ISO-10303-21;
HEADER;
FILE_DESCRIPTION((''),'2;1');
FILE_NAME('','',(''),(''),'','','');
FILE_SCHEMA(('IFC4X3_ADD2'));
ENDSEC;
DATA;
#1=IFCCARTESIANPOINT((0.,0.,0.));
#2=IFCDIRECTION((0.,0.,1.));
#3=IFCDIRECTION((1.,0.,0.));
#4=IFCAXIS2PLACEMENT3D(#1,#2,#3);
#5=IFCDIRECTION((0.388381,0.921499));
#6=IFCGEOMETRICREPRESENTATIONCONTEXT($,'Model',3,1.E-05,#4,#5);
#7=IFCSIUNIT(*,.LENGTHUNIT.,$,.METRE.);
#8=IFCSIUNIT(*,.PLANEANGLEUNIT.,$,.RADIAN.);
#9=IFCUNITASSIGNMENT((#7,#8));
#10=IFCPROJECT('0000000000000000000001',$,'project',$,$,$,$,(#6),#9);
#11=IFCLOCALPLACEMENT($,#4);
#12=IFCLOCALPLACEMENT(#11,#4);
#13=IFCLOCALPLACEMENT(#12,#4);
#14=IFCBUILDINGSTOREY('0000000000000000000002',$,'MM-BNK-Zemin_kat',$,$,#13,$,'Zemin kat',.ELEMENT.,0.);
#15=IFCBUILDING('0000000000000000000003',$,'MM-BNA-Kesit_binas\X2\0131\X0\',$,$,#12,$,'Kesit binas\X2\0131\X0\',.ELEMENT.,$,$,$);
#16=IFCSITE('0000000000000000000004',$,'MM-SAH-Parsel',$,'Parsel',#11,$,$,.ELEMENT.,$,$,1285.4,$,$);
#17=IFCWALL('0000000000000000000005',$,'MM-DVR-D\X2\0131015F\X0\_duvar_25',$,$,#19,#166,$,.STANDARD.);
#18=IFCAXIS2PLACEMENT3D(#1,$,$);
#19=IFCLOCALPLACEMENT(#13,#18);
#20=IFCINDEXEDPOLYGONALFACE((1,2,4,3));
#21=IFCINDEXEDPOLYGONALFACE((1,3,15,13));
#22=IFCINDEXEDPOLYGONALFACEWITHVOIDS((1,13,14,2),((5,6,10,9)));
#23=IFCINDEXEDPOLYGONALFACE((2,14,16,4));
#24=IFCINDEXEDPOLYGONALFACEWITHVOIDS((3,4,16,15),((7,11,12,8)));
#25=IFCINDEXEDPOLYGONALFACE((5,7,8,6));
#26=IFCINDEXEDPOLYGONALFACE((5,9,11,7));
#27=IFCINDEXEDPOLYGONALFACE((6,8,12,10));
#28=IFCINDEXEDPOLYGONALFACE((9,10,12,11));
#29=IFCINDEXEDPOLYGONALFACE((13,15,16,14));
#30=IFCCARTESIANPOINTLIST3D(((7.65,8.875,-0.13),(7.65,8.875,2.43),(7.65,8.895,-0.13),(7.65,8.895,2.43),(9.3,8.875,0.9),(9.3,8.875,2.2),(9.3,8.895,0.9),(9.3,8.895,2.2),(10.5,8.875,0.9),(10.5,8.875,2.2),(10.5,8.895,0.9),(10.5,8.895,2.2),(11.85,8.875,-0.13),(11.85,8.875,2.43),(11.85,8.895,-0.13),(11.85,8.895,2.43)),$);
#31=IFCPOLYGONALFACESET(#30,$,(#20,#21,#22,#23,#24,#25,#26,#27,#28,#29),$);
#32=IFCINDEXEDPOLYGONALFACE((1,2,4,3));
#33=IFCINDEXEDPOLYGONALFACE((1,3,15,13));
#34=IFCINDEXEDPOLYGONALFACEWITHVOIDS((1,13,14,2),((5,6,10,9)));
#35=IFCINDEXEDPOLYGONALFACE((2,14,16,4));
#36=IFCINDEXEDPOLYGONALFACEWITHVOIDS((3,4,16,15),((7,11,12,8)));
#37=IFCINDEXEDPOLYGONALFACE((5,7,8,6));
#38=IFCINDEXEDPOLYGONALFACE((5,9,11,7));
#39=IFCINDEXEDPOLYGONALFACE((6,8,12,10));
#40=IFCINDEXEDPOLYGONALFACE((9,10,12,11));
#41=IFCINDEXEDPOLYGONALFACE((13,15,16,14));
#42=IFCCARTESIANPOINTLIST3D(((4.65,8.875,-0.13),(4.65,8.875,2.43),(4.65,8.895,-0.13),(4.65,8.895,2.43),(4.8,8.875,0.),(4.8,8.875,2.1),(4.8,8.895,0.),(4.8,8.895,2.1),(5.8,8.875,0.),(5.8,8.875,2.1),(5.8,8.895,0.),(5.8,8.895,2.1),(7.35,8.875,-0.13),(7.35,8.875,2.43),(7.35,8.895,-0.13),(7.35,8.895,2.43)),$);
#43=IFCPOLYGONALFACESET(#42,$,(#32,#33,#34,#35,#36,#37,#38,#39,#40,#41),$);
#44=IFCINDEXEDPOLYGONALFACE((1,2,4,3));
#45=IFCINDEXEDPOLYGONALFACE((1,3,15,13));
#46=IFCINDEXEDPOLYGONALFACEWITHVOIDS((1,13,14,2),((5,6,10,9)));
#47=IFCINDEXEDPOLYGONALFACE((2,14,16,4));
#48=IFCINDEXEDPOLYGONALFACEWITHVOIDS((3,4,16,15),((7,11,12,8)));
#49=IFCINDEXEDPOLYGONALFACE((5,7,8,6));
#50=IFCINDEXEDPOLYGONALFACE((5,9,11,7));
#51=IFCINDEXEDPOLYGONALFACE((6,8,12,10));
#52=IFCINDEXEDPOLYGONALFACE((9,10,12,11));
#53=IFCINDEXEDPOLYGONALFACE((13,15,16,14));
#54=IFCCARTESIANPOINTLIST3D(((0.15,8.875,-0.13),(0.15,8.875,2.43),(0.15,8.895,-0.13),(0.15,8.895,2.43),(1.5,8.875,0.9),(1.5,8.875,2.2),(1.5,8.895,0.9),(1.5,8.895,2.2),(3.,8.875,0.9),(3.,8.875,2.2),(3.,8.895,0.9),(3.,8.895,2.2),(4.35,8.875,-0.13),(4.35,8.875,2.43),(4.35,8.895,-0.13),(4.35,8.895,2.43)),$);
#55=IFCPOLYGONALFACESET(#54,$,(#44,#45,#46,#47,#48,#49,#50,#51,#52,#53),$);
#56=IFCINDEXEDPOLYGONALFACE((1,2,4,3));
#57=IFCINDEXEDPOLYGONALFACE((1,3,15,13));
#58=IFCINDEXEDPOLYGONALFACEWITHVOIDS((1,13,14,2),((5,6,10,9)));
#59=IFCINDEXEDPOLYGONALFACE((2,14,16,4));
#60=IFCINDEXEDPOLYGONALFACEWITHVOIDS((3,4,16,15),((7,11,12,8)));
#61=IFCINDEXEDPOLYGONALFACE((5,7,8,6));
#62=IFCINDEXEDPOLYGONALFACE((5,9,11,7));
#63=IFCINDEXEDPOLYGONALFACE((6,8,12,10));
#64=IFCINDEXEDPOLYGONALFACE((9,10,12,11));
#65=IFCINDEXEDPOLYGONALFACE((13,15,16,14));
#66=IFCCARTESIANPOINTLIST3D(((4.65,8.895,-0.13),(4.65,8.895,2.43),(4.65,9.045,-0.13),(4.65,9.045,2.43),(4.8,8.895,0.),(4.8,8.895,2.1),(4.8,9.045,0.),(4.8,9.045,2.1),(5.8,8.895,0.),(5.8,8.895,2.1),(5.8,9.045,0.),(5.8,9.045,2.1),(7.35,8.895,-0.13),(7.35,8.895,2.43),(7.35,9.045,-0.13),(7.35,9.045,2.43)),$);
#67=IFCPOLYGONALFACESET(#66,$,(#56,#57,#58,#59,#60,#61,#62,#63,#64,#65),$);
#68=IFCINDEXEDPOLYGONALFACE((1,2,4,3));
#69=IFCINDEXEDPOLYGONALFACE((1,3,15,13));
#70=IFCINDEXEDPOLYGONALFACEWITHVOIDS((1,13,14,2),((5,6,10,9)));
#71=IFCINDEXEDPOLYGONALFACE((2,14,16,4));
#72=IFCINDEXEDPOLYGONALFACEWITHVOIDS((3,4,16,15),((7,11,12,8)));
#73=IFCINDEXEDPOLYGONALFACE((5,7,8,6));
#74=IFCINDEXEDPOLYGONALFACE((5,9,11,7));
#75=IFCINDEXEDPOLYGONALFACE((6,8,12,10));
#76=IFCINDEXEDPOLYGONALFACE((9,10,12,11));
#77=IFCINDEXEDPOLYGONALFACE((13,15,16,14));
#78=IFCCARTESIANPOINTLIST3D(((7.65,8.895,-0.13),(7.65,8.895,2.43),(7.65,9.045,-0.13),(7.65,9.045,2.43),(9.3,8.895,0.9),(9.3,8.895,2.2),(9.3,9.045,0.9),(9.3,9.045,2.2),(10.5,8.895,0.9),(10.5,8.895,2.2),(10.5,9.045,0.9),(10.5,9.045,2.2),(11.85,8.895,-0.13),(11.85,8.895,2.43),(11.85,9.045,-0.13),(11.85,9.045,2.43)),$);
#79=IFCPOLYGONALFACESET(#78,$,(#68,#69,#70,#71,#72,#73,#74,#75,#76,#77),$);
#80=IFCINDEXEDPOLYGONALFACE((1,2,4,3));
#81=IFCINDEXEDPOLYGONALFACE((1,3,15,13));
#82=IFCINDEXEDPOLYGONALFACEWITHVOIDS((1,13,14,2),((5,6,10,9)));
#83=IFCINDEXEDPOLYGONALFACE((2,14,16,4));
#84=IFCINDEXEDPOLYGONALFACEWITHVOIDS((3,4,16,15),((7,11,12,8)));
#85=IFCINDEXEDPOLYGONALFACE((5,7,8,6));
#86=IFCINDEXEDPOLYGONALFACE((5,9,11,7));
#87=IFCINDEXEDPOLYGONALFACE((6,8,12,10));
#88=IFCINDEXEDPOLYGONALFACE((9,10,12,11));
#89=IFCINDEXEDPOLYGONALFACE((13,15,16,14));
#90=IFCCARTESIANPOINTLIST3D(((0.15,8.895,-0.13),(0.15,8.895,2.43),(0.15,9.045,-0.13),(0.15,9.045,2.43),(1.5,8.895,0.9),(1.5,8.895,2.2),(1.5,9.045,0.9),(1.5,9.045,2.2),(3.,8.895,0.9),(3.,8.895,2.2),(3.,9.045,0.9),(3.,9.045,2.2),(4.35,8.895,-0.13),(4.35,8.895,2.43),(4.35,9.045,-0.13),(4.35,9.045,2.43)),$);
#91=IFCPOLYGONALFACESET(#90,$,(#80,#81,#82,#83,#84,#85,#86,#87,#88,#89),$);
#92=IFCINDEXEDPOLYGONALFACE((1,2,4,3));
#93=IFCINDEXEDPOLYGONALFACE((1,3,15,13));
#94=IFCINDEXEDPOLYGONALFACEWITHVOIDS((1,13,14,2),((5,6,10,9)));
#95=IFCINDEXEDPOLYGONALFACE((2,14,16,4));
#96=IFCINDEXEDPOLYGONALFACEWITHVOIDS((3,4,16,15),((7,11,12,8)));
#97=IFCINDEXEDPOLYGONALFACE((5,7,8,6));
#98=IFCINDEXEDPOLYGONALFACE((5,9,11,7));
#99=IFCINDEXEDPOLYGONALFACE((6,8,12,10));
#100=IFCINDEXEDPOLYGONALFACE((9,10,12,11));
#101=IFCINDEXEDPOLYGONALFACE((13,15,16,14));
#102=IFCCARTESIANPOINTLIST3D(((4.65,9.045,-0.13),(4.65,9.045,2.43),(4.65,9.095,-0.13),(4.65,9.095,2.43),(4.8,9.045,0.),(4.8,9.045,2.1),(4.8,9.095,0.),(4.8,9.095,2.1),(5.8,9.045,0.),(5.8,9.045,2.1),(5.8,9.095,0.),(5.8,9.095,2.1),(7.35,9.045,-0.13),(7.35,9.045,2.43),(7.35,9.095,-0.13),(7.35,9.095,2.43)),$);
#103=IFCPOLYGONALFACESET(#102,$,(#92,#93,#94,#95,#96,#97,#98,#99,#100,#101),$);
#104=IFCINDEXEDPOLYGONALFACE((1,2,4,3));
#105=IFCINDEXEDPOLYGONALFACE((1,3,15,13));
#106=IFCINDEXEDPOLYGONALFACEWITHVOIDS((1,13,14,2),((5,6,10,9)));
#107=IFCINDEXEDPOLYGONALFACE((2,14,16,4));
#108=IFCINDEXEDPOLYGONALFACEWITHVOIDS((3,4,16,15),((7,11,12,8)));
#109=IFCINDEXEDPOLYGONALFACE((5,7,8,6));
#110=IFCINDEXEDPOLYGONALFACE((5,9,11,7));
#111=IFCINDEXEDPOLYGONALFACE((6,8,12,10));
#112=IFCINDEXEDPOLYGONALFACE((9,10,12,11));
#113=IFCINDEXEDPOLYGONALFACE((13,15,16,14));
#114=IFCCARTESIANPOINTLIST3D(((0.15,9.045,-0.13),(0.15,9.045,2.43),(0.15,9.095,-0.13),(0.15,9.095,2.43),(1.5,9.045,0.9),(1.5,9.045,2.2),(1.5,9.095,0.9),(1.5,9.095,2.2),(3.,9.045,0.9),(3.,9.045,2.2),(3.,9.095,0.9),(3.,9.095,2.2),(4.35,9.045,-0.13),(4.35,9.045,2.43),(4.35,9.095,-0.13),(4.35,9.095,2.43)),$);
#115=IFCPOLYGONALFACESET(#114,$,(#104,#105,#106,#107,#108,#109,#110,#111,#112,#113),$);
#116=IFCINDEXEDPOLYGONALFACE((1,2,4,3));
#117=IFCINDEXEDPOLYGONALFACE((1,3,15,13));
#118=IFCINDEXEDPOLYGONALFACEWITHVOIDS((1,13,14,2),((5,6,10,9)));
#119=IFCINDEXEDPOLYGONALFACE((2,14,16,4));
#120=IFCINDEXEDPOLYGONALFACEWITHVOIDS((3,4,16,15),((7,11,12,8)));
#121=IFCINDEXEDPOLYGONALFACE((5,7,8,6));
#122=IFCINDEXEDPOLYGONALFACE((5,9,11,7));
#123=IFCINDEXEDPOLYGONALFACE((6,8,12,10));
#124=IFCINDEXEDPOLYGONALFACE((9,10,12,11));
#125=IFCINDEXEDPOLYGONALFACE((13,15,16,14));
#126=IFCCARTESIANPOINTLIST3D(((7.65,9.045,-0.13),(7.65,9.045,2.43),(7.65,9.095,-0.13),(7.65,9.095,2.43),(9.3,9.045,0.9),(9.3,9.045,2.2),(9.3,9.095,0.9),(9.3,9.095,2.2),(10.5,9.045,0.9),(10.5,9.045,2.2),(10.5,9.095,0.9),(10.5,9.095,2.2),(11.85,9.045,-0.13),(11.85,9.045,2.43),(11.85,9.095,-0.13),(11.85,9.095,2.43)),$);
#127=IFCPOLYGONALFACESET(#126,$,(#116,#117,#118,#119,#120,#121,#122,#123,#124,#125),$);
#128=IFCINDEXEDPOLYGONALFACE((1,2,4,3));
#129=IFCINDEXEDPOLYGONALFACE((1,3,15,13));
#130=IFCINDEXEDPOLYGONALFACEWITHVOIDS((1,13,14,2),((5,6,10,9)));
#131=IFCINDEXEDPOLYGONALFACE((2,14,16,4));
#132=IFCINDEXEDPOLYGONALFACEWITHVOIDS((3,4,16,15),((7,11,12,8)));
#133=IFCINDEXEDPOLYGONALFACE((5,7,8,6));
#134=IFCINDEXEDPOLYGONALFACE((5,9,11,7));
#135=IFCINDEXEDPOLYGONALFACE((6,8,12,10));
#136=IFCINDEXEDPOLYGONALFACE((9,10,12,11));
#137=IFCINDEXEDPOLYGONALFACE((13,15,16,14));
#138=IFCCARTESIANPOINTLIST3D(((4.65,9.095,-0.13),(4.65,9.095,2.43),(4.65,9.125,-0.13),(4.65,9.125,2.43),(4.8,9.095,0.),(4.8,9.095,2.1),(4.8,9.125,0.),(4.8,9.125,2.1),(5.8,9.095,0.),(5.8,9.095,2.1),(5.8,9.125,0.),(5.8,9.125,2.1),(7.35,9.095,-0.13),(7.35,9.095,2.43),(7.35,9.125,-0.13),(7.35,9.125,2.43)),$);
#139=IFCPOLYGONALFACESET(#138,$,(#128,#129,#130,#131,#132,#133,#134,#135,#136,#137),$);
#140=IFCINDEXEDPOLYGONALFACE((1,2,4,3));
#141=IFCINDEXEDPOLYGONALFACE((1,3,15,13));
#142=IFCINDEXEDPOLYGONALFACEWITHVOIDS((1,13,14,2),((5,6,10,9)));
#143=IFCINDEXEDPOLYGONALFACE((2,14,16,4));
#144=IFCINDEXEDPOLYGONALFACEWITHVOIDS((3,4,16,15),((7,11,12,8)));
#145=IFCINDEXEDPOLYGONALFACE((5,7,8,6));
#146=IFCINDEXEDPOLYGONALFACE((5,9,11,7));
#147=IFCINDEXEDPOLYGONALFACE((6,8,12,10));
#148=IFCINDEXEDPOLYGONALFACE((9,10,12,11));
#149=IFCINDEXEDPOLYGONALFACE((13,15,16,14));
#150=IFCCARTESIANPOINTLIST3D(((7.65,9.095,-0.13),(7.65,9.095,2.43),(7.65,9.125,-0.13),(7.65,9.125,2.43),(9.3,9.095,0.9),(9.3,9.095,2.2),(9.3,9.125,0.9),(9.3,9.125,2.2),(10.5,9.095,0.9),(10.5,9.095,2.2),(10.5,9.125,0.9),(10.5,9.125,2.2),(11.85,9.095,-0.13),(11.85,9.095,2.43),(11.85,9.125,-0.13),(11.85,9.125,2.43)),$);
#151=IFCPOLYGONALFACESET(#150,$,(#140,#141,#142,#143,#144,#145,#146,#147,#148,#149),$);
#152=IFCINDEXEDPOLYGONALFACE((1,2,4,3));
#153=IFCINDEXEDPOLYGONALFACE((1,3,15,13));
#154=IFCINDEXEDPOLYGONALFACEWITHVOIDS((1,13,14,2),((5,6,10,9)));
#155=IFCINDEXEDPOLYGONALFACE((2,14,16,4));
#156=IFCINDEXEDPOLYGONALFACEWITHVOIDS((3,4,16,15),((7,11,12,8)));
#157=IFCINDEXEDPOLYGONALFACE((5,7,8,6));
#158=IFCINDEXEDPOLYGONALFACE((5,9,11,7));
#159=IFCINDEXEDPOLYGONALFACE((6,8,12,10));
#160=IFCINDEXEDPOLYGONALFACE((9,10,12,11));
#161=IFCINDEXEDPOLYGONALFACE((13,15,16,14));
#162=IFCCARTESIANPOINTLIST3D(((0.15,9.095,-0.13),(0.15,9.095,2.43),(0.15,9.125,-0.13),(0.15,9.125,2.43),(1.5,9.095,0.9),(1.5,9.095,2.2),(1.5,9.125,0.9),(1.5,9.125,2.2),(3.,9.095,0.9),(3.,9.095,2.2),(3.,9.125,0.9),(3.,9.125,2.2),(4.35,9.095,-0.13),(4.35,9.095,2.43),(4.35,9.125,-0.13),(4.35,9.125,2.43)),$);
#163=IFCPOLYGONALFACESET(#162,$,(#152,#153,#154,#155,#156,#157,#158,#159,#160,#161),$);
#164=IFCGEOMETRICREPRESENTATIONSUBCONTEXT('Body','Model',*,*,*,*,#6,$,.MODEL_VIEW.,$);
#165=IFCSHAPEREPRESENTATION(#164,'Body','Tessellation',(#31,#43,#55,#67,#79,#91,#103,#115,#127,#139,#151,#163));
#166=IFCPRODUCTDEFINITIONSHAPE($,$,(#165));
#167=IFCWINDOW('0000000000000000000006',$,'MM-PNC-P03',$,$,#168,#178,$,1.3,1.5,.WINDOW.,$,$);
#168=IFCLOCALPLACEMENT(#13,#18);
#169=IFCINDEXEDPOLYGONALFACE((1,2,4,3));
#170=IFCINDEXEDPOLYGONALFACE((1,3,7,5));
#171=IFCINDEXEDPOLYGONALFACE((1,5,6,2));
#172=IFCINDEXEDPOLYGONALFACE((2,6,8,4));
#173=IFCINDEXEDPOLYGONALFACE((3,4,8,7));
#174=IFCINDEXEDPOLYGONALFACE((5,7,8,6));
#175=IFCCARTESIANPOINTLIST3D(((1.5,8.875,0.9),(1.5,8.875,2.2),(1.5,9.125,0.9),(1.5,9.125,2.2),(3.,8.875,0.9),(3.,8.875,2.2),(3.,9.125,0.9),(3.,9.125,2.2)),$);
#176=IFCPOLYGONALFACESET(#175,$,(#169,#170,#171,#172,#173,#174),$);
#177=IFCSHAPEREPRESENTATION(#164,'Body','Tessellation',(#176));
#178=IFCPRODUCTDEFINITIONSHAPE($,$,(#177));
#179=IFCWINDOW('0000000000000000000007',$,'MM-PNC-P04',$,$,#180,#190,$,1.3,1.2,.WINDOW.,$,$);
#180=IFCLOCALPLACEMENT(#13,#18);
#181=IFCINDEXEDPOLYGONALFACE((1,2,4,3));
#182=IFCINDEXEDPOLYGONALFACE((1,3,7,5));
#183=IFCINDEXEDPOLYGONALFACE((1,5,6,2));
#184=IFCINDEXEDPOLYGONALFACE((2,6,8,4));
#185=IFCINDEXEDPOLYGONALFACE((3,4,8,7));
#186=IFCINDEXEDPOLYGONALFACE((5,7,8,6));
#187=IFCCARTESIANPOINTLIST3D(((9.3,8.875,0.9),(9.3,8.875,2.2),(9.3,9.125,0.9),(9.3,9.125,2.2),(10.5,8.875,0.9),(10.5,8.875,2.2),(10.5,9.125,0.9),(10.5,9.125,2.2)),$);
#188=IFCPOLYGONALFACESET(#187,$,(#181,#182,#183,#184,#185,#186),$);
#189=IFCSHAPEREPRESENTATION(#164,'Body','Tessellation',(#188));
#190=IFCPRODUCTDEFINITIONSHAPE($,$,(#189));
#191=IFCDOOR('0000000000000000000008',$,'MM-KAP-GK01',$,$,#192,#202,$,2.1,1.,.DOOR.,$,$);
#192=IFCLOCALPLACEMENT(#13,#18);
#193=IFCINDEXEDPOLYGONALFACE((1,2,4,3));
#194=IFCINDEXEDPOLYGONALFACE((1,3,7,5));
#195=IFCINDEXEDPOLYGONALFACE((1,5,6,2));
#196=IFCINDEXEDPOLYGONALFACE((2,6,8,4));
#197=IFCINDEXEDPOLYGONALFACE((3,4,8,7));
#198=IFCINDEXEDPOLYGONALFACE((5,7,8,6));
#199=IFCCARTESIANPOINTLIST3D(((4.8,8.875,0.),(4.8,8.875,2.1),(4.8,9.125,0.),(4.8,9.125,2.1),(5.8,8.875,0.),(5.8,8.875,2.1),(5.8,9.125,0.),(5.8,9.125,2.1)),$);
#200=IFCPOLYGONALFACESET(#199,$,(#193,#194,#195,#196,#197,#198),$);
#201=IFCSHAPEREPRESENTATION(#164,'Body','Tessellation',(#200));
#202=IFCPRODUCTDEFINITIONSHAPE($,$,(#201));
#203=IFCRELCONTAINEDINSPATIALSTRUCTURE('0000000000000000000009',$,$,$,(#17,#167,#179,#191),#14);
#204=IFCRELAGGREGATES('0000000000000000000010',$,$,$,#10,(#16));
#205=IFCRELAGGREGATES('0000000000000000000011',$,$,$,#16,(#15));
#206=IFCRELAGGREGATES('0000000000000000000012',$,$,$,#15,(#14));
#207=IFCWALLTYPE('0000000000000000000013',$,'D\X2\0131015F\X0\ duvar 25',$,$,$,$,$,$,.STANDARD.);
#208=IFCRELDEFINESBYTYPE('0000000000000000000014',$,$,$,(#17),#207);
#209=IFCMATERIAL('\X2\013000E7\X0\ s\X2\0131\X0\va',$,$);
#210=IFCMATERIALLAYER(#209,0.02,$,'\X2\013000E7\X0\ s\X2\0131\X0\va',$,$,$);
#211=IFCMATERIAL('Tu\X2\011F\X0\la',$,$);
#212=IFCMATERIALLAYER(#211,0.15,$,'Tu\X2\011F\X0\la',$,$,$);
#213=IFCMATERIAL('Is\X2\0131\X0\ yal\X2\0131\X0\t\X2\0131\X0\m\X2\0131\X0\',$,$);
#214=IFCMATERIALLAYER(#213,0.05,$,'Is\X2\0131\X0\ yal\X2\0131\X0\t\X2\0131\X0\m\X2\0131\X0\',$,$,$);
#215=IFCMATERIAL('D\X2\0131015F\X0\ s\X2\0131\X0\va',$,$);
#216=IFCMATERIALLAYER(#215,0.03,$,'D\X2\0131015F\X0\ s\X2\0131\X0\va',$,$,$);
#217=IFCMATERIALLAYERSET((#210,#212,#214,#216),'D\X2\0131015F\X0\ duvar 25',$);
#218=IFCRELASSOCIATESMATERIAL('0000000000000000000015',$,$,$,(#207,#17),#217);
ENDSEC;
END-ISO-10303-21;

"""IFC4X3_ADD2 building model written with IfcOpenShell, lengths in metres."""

from ifc_helpers import new_model, si_unit, direction, frame, origin, origin_with_axes, place, context, subcontext, project, spatial, polyline, outline, extrude, material, layer, layer_set, type_object, element, fill, save


model = new_model("IFC4X3_ADD2")

# Units and contexts
model_context = context("Model", 3, precision=1e-05, world=origin_with_axes(), true_north=direction((0.388381, 0.921499)))
body_context = subcontext(model_context, "Body", "Model", "MODEL_VIEW")
ifc_project = project(units=[si_unit("LENGTHUNIT", "METRE"), si_unit("PLANEANGLEUNIT", "RADIAN")], contexts=[model_context])

# Site, building, storey
site_placement = place(None, origin_with_axes())
site = spatial("IfcSite", under=ifc_project, at=site_placement, Name="MM-SAH-Parsel", ObjectType="Parsel", CompositionType="ELEMENT", RefElevation=1285.4)
building_placement = place(site_placement, origin_with_axes())
building = spatial("IfcBuilding", under=site, at=building_placement, Name="MM-BNA-Kesit_binası", LongName="Kesit binası", CompositionType="ELEMENT")
storey_placement = place(building_placement, origin_with_axes())
storey = spatial("IfcBuildingStorey", under=building, at=storey_placement, Name="MM-BNK-Zemin_kat", LongName="Zemin kat", CompositionType="ELEMENT", Elevation=0.0)

# Shared definitions
ifc_material_1 = material(Name="İç sıva")
ifc_layer_1 = layer(ifc_material_1, 0.02, Name="İç sıva")
ifc_material_2 = material(Name="Tuğla")
ifc_layer_2 = layer(ifc_material_2, 0.15, Name="Tuğla")
ifc_material_3 = material(Name="Isı yalıtımı")
ifc_layer_3 = layer(ifc_material_3, 0.05, Name="Isı yalıtımı")
ifc_material_4 = material(Name="Dış sıva")
ifc_layer_4 = layer(ifc_material_4, 0.03, Name="Dış sıva")
ifc_layer_set_1 = layer_set([ifc_layer_1, ifc_layer_2, ifc_layer_3, ifc_layer_4], Name="Dış duvar 25")
wall_type_1 = type_object("IfcWallType", Name="Dış duvar 25", PredefinedType="STANDARD", material=ifc_layer_set_1)

# Wall, openings, windows, door
wall_1_placement = place(storey_placement, origin_with_axes())
wall_1 = element("IfcWall", 1, at=wall_1_placement, inside=storey, type_object=wall_type_1, material=ifc_layer_set_1, Name="MM-DVR-Dış_duvar_25", PredefinedType="STANDARD", context=body_context, shape_type="SweptSolid", body=[
    extrude(outline(polyline([(11.85, 8.895), (7.65, 8.895), (7.65, 8.875), (11.85, 8.875), (11.85, 8.895)])), frame((0.0, 0.0, -0.13)), (0.0, 0.0, 1.0), 2.56),
    extrude(outline(polyline([(7.35, 8.895), (4.65, 8.895), (4.65, 8.875), (7.35, 8.875), (7.35, 8.895)])), frame((0.0, 0.0, -0.13)), (0.0, 0.0, 1.0), 2.56),
    extrude(outline(polyline([(4.35, 8.895), (0.15, 8.895), (0.15, 8.875), (4.35, 8.875), (4.35, 8.895)])), frame((0.0, 0.0, -0.13)), (0.0, 0.0, 1.0), 2.56),
    extrude(outline(polyline([(7.35, 9.045), (4.65, 9.045), (4.65, 8.895), (7.35, 8.895), (7.35, 9.045)])), frame((0.0, 0.0, -0.13)), (0.0, 0.0, 1.0), 2.56),
    extrude(outline(polyline([(11.85, 9.045), (7.65, 9.045), (7.65, 8.895), (11.85, 8.895), (11.85, 9.045)])), frame((0.0, 0.0, -0.13)), (0.0, 0.0, 1.0), 2.56),
    extrude(outline(polyline([(4.35, 9.045), (0.15, 9.045), (0.15, 8.895), (4.35, 8.895), (4.35, 9.045)])), frame((0.0, 0.0, -0.13)), (0.0, 0.0, 1.0), 2.56),
    extrude(outline(polyline([(7.35, 9.095), (4.65, 9.095), (4.65, 9.045), (7.35, 9.045), (7.35, 9.095)])), frame((0.0, 0.0, -0.13)), (0.0, 0.0, 1.0), 2.56),
    extrude(outline(polyline([(4.35, 9.095), (0.15, 9.095), (0.15, 9.045), (4.35, 9.045), (4.35, 9.095)])), frame((0.0, 0.0, -0.13)), (0.0, 0.0, 1.0), 2.56),
    extrude(outline(polyline([(11.85, 9.095), (7.65, 9.095), (7.65, 9.045), (11.85, 9.045), (11.85, 9.095)])), frame((0.0, 0.0, -0.13)), (0.0, 0.0, 1.0), 2.56),
    extrude(outline(polyline([(7.35, 9.125), (4.65, 9.125), (4.65, 9.095), (7.35, 9.095), (7.35, 9.125)])), frame((0.0, 0.0, -0.13)), (0.0, 0.0, 1.0), 2.56),
    extrude(outline(polyline([(11.85, 9.125), (7.65, 9.125), (7.65, 9.095), (11.85, 9.095), (11.85, 9.125)])), frame((0.0, 0.0, -0.13)), (0.0, 0.0, 1.0), 2.56),
    extrude(outline(polyline([(4.35, 9.125), (0.15, 9.125), (0.15, 9.095), (4.35, 9.095), (4.35, 9.125)])), frame((0.0, 0.0, -0.13)), (0.0, 0.0, 1.0), 2.56),
])
opening_1_placement = place(storey_placement, origin_with_axes())
opening_1 = element("IfcOpeningElement", 2, at=opening_1_placement, cuts=wall_1, PredefinedType="OPENING", context=body_context, shape_type="SweptSolid", body=[
    extrude(outline(polyline([(3.0, 8.875), (1.5, 8.875), (1.5, 9.125), (3.0, 9.125), (3.0, 8.875)])), frame((0.0, 0.0, 0.9)), (0.0, 0.0, 1.0), 1.3),
])
opening_2_placement = place(storey_placement, origin_with_axes())
opening_2 = element("IfcOpeningElement", 3, at=opening_2_placement, cuts=wall_1, PredefinedType="OPENING", context=body_context, shape_type="SweptSolid", body=[
    extrude(outline(polyline([(10.5, 8.875), (9.3, 8.875), (9.3, 9.125), (10.5, 9.125), (10.5, 8.875)])), frame((0.0, 0.0, 0.9)), (0.0, 0.0, 1.0), 1.3),
])
opening_3_placement = place(storey_placement, origin_with_axes())
opening_3 = element("IfcOpeningElement", 4, at=opening_3_placement, cuts=wall_1, PredefinedType="OPENING", context=body_context, shape_type="SweptSolid", body=[
    extrude(outline(polyline([(5.8, 8.875), (4.8, 8.875), (4.8, 9.125), (5.8, 9.125), (5.8, 8.875)])), origin(), (0.0, 0.0, 1.0), 2.1),
])
window_1_placement = place(storey_placement, origin_with_axes())
window_1 = element("IfcWindow", 5, at=window_1_placement, inside=storey, Name="MM-PNC-P03", OverallHeight=1.3, OverallWidth=1.5, PredefinedType="WINDOW", context=body_context, shape_type="SweptSolid", body=[
    extrude(outline(polyline([(3.0, 8.875), (1.5, 8.875), (1.5, 9.125), (3.0, 9.125), (3.0, 8.875)])), frame((0.0, 0.0, 0.9)), (0.0, 0.0, 1.0), 1.3),
])
fill(opening_1, window_1)
window_2_placement = place(storey_placement, origin_with_axes())
window_2 = element("IfcWindow", 6, at=window_2_placement, inside=storey, Name="MM-PNC-P04", OverallHeight=1.3, OverallWidth=1.2, PredefinedType="WINDOW", context=body_context, shape_type="SweptSolid", body=[
    extrude(outline(polyline([(10.5, 8.875), (9.3, 8.875), (9.3, 9.125), (10.5, 9.125), (10.5, 8.875)])), frame((0.0, 0.0, 0.9)), (0.0, 0.0, 1.0), 1.3),
])
fill(opening_2, window_2)
door_1_placement = place(storey_placement, origin_with_axes())
door_1 = element("IfcDoor", 7, at=door_1_placement, inside=storey, Name="MM-KAP-GK01", OverallHeight=2.1, OverallWidth=1.0, PredefinedType="DOOR", context=body_context, shape_type="SweptSolid", body=[
    extrude(outline(polyline([(5.8, 8.875), (4.8, 8.875), (4.8, 9.125), (5.8, 9.125), (5.8, 8.875)])), origin(), (0.0, 0.0, 1.0), 2.1),
])
fill(opening_3, door_1)

save(model, "model.ifc")
